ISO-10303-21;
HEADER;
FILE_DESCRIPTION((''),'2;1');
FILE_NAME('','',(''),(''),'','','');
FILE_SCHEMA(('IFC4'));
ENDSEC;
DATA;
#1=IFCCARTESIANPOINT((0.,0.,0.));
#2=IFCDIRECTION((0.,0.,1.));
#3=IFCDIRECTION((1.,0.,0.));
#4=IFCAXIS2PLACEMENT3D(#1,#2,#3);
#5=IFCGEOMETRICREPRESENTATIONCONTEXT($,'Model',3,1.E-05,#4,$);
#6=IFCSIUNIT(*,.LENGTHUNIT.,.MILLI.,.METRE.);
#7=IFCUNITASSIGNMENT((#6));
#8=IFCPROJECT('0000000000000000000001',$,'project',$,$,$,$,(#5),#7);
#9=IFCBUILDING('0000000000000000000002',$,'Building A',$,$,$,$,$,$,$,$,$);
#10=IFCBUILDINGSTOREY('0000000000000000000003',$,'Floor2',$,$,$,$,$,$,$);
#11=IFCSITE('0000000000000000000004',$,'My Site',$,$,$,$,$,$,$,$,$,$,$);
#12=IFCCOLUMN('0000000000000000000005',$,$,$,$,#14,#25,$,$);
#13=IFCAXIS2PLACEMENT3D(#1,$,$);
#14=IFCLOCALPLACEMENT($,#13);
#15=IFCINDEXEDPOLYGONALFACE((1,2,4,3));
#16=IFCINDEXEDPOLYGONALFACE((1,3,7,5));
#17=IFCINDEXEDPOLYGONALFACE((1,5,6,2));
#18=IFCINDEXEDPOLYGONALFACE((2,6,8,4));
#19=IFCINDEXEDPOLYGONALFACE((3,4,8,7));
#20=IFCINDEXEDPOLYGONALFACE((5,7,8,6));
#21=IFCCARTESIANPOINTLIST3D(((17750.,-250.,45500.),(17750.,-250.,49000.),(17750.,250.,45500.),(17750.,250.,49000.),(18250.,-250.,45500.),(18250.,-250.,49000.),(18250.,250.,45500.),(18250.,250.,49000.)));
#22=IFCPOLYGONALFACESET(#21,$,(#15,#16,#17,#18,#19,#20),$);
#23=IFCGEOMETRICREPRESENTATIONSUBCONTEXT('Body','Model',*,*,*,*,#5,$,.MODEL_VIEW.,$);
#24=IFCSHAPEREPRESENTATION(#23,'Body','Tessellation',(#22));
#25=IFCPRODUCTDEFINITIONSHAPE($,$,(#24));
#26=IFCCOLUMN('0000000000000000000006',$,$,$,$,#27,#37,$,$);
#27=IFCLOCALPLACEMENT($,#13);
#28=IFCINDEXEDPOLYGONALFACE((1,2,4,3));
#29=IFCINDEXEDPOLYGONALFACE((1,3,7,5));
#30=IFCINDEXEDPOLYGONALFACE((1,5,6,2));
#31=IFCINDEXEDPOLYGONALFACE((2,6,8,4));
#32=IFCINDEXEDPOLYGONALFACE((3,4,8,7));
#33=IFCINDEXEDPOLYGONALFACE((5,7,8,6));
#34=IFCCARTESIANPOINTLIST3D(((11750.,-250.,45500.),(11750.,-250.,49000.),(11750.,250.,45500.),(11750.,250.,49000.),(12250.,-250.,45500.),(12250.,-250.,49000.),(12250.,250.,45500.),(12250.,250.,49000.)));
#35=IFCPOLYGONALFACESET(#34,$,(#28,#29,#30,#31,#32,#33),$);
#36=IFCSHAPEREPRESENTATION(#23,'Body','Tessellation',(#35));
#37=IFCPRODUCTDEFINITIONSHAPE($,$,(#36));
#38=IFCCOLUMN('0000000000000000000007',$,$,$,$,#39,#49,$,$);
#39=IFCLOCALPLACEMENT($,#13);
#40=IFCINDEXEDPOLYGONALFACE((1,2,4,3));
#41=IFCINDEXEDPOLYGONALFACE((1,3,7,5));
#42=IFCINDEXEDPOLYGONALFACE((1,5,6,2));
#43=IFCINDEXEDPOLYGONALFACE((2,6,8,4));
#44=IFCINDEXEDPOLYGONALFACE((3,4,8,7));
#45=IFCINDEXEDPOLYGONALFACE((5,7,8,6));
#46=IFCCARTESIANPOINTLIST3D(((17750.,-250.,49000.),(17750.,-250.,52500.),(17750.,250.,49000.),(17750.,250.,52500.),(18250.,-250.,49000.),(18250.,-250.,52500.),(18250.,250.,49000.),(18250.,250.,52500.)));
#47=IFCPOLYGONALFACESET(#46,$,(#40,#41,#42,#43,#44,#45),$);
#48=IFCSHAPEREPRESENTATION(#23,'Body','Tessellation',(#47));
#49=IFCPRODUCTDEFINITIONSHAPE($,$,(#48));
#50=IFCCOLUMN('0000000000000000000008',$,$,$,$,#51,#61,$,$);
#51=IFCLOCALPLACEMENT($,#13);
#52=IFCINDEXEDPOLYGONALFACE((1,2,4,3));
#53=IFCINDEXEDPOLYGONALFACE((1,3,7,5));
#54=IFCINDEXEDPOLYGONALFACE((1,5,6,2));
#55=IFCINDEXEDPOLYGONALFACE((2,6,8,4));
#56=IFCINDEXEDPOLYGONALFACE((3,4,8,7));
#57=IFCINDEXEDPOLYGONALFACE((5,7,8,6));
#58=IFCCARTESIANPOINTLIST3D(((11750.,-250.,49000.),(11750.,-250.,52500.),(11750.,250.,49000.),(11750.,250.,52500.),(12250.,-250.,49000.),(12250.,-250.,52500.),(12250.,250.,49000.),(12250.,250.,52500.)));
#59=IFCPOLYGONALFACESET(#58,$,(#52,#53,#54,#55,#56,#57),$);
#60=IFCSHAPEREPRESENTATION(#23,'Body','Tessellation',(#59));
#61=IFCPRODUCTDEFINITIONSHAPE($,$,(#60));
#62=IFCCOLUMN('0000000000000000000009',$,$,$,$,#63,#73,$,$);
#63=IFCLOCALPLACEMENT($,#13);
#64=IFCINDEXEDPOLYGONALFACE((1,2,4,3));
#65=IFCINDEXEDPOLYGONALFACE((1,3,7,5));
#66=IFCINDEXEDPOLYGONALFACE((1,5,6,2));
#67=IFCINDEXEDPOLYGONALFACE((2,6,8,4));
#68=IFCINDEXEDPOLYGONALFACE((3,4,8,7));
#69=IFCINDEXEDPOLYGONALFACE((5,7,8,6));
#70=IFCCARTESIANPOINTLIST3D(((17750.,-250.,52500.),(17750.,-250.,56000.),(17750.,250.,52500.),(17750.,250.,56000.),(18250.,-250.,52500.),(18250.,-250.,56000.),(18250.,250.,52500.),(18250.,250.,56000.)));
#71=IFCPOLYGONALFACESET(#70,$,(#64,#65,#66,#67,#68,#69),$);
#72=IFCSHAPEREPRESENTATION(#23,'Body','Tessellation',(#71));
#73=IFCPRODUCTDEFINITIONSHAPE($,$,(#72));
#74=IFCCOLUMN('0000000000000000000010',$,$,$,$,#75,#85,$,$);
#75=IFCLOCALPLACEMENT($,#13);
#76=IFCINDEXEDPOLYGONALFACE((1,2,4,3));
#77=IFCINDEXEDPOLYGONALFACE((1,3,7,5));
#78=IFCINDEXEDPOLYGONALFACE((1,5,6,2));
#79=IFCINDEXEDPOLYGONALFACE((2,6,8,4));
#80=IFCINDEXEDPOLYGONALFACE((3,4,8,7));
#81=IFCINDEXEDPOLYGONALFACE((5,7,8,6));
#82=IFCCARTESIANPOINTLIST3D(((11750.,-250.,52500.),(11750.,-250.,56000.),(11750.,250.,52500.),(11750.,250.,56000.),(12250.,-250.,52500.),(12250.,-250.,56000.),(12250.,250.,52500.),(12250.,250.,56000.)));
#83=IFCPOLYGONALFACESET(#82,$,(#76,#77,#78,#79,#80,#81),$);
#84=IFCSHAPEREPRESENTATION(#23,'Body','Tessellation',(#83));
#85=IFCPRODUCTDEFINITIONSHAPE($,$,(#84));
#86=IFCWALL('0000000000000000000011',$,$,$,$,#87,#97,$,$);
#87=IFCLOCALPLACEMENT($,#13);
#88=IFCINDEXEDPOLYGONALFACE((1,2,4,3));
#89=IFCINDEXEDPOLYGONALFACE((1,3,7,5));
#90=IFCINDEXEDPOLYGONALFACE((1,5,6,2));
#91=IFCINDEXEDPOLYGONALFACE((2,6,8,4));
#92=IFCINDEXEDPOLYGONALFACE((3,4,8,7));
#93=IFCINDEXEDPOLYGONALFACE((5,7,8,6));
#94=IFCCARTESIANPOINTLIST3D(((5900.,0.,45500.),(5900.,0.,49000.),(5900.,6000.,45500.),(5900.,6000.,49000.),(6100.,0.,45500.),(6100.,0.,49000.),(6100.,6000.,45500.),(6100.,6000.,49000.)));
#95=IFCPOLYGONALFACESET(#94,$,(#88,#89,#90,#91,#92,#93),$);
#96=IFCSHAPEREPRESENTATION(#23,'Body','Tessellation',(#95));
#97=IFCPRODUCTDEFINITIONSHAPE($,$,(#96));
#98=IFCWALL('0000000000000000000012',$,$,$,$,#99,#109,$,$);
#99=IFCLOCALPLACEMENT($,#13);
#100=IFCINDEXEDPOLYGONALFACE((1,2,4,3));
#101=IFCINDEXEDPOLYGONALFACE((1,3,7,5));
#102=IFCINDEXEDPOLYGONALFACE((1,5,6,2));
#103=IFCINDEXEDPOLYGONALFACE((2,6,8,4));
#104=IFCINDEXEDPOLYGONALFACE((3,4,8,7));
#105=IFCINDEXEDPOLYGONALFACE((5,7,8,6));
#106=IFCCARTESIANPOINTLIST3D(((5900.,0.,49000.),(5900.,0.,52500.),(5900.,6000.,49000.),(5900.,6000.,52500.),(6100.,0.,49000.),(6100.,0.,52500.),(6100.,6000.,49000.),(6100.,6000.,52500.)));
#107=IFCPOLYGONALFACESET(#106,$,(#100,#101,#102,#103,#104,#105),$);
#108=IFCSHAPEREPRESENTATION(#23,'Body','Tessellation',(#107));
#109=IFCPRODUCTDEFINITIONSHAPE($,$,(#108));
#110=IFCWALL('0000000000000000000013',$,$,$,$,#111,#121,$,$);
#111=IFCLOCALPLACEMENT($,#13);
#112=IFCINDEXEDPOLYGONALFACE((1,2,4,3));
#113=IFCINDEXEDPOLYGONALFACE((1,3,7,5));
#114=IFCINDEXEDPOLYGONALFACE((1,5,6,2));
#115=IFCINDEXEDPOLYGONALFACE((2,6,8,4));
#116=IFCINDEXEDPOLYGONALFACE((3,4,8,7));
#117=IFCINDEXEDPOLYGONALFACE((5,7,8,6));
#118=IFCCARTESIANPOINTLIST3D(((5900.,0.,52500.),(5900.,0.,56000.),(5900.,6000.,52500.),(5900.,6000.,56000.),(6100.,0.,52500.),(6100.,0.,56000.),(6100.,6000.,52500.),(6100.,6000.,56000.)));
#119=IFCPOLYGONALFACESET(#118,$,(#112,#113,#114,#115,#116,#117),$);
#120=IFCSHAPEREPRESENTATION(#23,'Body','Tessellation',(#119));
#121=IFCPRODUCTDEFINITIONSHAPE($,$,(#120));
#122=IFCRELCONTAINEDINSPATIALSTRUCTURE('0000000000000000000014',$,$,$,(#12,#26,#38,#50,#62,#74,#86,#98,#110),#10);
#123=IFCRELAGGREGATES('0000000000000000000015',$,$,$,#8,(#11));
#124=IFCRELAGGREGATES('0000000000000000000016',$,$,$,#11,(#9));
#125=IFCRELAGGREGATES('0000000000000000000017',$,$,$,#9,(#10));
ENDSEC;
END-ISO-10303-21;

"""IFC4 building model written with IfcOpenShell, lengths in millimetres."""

from ifc_helpers import new_model, si_unit, frame, origin_with_axes, place, context, subcontext, project, spatial, line, indexed_curve, outline, extrude, element, save


model = new_model("IFC4")

# Units and contexts
model_context = context("Model", 3, precision=1e-05, world=origin_with_axes())
body_context = subcontext(model_context, "Body", "Model", "MODEL_VIEW")
ifc_project = project(units=[si_unit("LENGTHUNIT", "METRE", prefix="MILLI")], contexts=[model_context])

# Site, building, storey
site = spatial("IfcSite", under=ifc_project, Name="My Site")
building = spatial("IfcBuilding", under=site, Name="Building A")
storey = spatial("IfcBuildingStorey", under=building, Name="Floor2")

# Columns
for number, where, z_axis, x_axis in (
    (1, (18000.0, 0.0, 45500.0), (0.0, 0.0, 1.0), (1.0, 0.0, 0.0)),
    (2, (12000.0, 0.0, 45500.0), (0.0, 0.0, 1.0), (1.0, 0.0, 0.0)),
    (3, (18000.0, 0.0, 49000.0), (0.0, 0.0, 1.0), (1.0, 0.0, 0.0)),
    (4, (12000.0, 0.0, 49000.0), (0.0, 0.0, 1.0), (1.0, 0.0, 0.0)),
    (5, (18000.0, 0.0, 52500.0), (0.0, 0.0, 1.0), (1.0, 0.0, 0.0)),
    (6, (12000.0, 0.0, 52500.0), (0.0, 0.0, 1.0), (1.0, 0.0, 0.0)),
):
    element("IfcColumn", number, at=place(None, frame(where, z_axis=z_axis, x_axis=x_axis)), inside=storey, context=body_context, shape_type="SweptSolid", body=[
        extrude(outline(indexed_curve([(-250.0, -250.0), (250.0, -250.0), (250.0, 250.0), (-250.0, 250.0)], segments=[line(1, 2, 3, 4, 1)])), origin_with_axes(), (0.0, 0.0, 1.0), 3500.0),
    ])

# Walls
for number, where, z_axis, x_axis in (
    (7, (6100.0, 0.0, 45500.0), (0.0, 0.0, 1.0), (0.0, 1.0, 0.0)),
    (8, (6100.0, 0.0, 49000.0), (0.0, 0.0, 1.0), (0.0, 1.0, 0.0)),
    (9, (6100.0, 0.0, 52500.0), (0.0, 0.0, 1.0), (0.0, 1.0, 0.0)),
):
    element("IfcWall", number, at=place(None, frame(where, z_axis=z_axis, x_axis=x_axis)), inside=storey, context=body_context, shape_type="SweptSolid", body=[
        extrude(outline(indexed_curve([(0.0, 0.0), (0.0, 200.0), (6000.0, 200.0), (6000.0, 0.0), (0.0, 0.0)], self_intersect=False)), origin_with_axes(), (0.0, 0.0, 1.0), 3500.0),
    ])

save(model, "model.ifc")
